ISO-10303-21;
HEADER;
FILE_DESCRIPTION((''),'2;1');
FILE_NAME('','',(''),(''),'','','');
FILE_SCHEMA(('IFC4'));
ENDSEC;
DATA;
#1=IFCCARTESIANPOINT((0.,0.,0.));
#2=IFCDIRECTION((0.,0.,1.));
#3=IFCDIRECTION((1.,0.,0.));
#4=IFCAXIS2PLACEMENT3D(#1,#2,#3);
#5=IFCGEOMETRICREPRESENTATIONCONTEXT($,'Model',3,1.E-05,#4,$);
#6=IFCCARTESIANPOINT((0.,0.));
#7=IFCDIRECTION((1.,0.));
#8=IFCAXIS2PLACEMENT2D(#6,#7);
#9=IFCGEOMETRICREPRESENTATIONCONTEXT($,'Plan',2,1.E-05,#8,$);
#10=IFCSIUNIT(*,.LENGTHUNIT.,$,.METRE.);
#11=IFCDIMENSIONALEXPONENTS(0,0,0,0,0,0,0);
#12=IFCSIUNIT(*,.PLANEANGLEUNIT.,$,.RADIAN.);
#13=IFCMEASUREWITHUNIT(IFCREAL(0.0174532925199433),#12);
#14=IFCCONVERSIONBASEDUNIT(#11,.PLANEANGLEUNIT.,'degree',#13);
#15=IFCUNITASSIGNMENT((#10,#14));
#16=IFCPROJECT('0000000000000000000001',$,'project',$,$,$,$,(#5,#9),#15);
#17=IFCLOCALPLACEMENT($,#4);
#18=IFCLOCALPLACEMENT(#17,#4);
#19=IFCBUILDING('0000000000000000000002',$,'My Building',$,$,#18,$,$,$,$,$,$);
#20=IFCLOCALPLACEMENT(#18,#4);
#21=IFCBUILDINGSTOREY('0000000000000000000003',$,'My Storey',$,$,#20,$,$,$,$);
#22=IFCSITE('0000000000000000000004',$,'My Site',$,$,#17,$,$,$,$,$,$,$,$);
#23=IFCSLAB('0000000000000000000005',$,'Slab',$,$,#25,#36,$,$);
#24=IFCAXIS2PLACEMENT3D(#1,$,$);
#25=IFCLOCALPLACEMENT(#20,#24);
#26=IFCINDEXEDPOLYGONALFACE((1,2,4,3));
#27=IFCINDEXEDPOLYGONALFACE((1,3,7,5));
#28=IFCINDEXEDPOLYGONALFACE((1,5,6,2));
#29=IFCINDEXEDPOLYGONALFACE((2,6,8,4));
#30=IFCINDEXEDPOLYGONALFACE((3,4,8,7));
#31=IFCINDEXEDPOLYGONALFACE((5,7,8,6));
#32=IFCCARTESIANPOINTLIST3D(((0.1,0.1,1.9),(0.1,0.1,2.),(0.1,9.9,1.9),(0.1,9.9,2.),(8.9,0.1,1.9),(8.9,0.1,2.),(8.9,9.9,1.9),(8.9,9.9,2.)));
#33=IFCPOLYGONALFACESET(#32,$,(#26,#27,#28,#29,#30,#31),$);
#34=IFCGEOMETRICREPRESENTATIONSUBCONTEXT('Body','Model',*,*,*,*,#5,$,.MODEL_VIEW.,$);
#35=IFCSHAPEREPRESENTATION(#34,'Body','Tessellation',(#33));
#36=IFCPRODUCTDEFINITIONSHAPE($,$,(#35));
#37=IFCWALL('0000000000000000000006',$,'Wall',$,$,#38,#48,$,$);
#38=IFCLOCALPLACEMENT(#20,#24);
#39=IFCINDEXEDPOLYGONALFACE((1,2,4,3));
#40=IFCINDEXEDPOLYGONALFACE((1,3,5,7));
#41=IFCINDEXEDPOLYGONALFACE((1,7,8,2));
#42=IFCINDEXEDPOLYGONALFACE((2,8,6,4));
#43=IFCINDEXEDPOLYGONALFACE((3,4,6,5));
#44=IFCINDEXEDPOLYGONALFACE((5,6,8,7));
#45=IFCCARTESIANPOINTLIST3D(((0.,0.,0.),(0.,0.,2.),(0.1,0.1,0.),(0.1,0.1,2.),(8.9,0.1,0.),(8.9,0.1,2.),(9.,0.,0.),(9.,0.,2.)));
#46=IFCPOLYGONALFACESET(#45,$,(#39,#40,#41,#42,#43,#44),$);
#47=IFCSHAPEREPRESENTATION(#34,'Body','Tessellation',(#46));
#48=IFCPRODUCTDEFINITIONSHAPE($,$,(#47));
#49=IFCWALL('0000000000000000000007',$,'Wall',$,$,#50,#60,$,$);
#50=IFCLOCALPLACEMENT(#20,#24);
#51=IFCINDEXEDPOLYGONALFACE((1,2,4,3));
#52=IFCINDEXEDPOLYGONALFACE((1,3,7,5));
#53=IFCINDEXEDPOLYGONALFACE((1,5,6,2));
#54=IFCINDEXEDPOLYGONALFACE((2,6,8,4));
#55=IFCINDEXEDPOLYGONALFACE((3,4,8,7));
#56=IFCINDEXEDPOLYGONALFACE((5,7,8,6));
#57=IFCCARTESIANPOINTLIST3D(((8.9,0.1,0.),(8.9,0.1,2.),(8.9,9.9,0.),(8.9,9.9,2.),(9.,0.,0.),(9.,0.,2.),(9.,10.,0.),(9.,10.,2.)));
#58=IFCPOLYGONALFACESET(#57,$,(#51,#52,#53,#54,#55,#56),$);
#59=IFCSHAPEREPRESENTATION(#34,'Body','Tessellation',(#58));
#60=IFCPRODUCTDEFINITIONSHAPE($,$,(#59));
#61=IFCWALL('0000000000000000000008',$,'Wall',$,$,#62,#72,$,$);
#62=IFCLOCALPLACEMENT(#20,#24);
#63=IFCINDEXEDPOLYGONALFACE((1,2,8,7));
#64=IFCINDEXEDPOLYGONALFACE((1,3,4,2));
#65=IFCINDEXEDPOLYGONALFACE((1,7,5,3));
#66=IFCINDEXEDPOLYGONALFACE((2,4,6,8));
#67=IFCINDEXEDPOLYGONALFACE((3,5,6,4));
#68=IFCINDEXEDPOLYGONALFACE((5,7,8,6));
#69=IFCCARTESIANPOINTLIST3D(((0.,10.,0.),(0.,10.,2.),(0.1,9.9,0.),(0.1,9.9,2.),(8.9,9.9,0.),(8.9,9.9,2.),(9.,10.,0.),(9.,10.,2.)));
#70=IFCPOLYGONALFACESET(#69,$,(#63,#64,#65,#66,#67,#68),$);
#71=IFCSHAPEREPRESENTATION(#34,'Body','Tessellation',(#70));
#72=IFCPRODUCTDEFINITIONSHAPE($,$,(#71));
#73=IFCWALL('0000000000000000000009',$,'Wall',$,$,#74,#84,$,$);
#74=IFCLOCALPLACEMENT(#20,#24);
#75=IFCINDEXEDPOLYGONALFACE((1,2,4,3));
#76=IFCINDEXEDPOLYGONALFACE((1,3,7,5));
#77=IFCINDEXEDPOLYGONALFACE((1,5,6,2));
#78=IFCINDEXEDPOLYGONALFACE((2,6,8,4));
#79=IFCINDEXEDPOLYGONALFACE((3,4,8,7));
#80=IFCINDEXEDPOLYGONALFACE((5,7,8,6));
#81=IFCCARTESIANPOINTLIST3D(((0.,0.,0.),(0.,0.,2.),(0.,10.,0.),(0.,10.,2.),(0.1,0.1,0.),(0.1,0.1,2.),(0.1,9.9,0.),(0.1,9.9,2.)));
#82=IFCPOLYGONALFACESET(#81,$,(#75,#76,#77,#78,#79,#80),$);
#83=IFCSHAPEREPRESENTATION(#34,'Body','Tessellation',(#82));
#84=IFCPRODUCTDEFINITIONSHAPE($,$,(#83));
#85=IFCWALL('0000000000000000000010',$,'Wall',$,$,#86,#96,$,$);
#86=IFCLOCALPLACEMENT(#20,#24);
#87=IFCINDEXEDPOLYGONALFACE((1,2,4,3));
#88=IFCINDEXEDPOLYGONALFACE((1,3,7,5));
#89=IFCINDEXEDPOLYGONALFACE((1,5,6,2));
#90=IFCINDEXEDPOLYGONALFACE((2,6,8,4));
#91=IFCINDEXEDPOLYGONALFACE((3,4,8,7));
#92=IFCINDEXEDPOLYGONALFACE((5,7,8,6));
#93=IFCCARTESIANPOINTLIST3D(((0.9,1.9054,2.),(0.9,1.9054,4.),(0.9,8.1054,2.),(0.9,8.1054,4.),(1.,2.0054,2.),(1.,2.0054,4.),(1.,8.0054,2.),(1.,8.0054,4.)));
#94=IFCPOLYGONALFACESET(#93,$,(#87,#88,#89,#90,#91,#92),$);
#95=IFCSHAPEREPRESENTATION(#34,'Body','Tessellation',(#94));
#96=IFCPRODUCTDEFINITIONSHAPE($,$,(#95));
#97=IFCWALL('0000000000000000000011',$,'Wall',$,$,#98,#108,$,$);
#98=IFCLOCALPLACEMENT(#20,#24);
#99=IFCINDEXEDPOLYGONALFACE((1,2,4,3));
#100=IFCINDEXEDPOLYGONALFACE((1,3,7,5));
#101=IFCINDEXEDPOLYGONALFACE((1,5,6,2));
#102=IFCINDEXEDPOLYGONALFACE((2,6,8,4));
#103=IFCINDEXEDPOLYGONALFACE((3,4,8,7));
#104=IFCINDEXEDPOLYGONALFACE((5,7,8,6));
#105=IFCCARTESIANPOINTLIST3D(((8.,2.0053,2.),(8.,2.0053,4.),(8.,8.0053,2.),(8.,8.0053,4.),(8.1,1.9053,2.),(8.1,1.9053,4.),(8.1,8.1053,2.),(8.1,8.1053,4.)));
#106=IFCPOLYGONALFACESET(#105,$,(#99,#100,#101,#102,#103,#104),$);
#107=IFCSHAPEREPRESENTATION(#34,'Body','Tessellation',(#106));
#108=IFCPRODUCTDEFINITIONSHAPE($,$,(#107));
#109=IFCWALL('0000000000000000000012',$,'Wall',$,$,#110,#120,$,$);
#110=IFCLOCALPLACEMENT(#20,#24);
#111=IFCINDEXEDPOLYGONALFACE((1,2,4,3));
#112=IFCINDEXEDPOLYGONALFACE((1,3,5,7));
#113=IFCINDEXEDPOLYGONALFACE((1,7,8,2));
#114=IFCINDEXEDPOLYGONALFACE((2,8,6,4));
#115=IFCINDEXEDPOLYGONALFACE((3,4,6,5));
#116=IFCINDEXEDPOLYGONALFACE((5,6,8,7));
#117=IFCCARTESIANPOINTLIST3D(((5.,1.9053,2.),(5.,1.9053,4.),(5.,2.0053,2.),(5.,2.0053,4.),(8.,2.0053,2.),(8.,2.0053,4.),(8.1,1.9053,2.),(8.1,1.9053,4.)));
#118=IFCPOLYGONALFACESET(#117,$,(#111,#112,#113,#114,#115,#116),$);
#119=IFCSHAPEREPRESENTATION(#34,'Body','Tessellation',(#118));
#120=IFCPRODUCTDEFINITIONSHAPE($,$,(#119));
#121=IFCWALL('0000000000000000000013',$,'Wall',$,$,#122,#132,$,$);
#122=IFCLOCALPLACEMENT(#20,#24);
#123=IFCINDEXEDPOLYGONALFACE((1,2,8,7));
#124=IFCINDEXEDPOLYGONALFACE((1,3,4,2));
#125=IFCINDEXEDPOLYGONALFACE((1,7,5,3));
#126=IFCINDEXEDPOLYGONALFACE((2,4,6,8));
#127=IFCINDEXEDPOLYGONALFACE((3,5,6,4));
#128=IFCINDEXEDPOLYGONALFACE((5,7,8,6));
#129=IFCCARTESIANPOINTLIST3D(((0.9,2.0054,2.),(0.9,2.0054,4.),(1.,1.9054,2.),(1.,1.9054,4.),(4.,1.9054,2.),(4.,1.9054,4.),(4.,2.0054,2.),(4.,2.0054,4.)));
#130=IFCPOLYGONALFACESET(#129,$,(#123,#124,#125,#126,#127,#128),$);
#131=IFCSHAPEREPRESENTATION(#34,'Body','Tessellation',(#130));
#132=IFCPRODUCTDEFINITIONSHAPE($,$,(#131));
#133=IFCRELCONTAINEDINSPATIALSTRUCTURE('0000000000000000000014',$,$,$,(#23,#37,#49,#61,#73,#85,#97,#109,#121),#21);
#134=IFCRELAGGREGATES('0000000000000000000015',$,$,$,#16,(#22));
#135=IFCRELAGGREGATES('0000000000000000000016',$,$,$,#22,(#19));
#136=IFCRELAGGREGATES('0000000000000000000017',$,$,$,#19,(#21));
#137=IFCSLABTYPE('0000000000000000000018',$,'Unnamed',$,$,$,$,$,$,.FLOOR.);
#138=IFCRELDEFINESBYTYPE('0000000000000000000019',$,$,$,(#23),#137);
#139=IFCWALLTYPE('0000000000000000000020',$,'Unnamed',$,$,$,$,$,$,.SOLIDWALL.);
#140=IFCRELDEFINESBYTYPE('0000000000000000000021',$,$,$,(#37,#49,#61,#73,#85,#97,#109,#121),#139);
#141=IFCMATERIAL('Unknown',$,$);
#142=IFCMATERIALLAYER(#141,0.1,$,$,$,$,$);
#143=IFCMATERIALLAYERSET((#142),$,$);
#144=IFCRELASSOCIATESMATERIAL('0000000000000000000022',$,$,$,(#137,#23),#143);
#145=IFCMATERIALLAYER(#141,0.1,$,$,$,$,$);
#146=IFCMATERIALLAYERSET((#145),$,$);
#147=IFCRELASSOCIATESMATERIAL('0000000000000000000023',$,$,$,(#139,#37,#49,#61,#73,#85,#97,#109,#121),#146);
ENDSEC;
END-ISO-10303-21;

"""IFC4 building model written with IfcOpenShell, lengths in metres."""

from ifc_helpers import new_model, entity, si_unit, converted_unit, frame, origin_with_axes, origin_2d_with_axis, place, context, subcontext, project, spatial, indexed_curve, outline, extrude, clip, halfspace, material, layer, layer_set, layer_usage, type_object, element, save


model = new_model("IFC4")

# Units and contexts
model_context = context("Model", 3, precision=1e-05, world=origin_with_axes())
plan_context = context("Plan", 2, precision=1e-05, world=origin_2d_with_axis())
body_context_1 = subcontext(model_context, "Body", "Model", "MODEL_VIEW")
ifc_project = project(units=[si_unit("LENGTHUNIT", "METRE"), converted_unit("PLANEANGLEUNIT", "degree", entity("IfcReal", 0.0174532925199433), si_unit("PLANEANGLEUNIT", "RADIAN"), dimensions=[0, 0, 0, 0, 0, 0, 0])], contexts=[model_context, plan_context])

# Site, building, storey
site_placement = place(None, origin_with_axes())
site = spatial("IfcSite", under=ifc_project, at=site_placement, Name="My Site")
building_placement = place(site_placement, origin_with_axes())
building = spatial("IfcBuilding", under=site, at=building_placement, Name="My Building")
storey_placement = place(building_placement, origin_with_axes())
storey = spatial("IfcBuildingStorey", under=building, at=storey_placement, Name="My Storey")

# Slab
ifc_material = material(Name="Unknown")
ifc_layer_1 = layer(ifc_material, 0.1)
ifc_layer_set_1 = layer_set([ifc_layer_1])
ifc_layer_usage_1 = layer_usage(ifc_layer_set_1, "AXIS3", "POSITIVE", -0.1)
slab_type = type_object("IfcSlabType", Name="Unnamed", PredefinedType="FLOOR", material=ifc_layer_set_1)
slab_placement = place(storey_placement, frame((0.1, 9.9, 2.0), z_axis=(0.0, 0.0, 1.0), x_axis=(1.0, 0.0, 0.0)))
element("IfcSlab", 1, at=slab_placement, inside=storey, type_object=slab_type, material=ifc_layer_usage_1, Name="Slab", context=body_context_1, shape_type="SweptSolid", body=[
    extrude(outline(indexed_curve([(0.0, 0.0), (8.8, 0.0), (8.8, -9.8), (0.0, -9.8), (0.0, 0.0)])), frame((0.0, 0.0, -0.1), z_axis=(0.0, 0.0, 1.0), x_axis=(1.0, 0.0, 0.0)), (0.0, 0.0, 1.0), 0.1),
])

# Walls
ifc_layer_2 = layer(ifc_material, 0.1)
ifc_layer_set_2 = layer_set([ifc_layer_2])
ifc_layer_usage_2 = layer_usage(ifc_layer_set_2, "AXIS2", "POSITIVE", 0.0)
wall_type = type_object("IfcWallType", Name="Unnamed", PredefinedType="SOLIDWALL", material=ifc_layer_set_2)
wall_1_placement = place(storey_placement, origin_with_axes())
element("IfcWall", 2, at=wall_1_placement, inside=storey, type_object=wall_type, material=ifc_layer_usage_2, Name="Wall", context=body_context_1, shape_type="Clipping", body=[
    clip(clip(extrude(outline(indexed_curve([(0.0, 0.0), (0.0, 0.1), (9.0, 0.1), (9.0, 0.0), (0.0, 0.0)], self_intersect=False)), origin_with_axes(), (0.0, 0.0, 1.0), 2.0), halfspace(frame((9.0, 0.0, 0.0), z_axis=(0.707105, 0.707108, 0.0), x_axis=(0.707108, -0.707105, 0.0)), False)), halfspace(frame((0.0, 0.0, 0.0), z_axis=(-0.707107, 0.707107, 0.0), x_axis=(0.707107, 0.707107, 0.0)), False)),
])
ifc_layer_usage_3 = layer_usage(ifc_layer_set_2, "AXIS2", "POSITIVE", 0.0)
wall_2_placement = place(storey_placement, frame((9.0, 0.0, 0.0), z_axis=(0.0, 0.0, 1.0), x_axis=(0.0, 1.0, 0.0)))
element("IfcWall", 3, at=wall_2_placement, inside=storey, type_object=wall_type, material=ifc_layer_usage_3, Name="Wall", context=body_context_1, shape_type="Clipping", body=[
    clip(clip(extrude(outline(indexed_curve([(0.0, 0.0), (0.0, 0.1), (10.0, 0.1), (10.0, 0.0), (0.0, 0.0)], self_intersect=False)), origin_with_axes(), (0.0, 0.0, 1.0), 2.0), halfspace(frame((10.0, 0.0, 0.0), z_axis=(0.707107, 0.707107, 0.0), x_axis=(0.707107, -0.707107, 0.0)), False)), halfspace(frame((0.0, 0.0, 0.0), z_axis=(-0.707108, 0.707105, 0.0), x_axis=(0.707105, 0.707108, 0.0)), False)),
])
ifc_layer_usage_4 = layer_usage(ifc_layer_set_2, "AXIS2", "POSITIVE", 0.0)
wall_3_placement = place(storey_placement, frame((9.0, 10.0, 0.0), z_axis=(0.0, 0.0, 1.0), x_axis=(-1.0, 0.0, 0.0)))
element("IfcWall", 4, at=wall_3_placement, inside=storey, type_object=wall_type, material=ifc_layer_usage_4, Name="Wall", context=body_context_1, shape_type="Clipping", body=[
    clip(clip(extrude(outline(indexed_curve([(0.0, 0.0), (0.0, 0.1), (9.0, 0.1), (9.0, 0.0), (0.0, 0.0)], self_intersect=False)), origin_with_axes(), (0.0, 0.0, 1.0), 2.0), halfspace(frame((9.0, 0.0, 0.0), z_axis=(0.707108, 0.707106, 0.0), x_axis=(0.707106, -0.707108, 0.0)), False)), halfspace(frame((0.0, 0.0, 0.0), z_axis=(-0.707107, 0.707107, 0.0), x_axis=(0.707107, 0.707107, 0.0)), False)),
])
ifc_layer_usage_5 = layer_usage(ifc_layer_set_2, "AXIS2", "POSITIVE", 0.0)
wall_4_placement = place(storey_placement, frame((0.0, 10.0, 0.0), z_axis=(0.0, 0.0, 1.0), x_axis=(0.0, -1.0, 0.0)))
element("IfcWall", 5, at=wall_4_placement, inside=storey, type_object=wall_type, material=ifc_layer_usage_5, Name="Wall", context=body_context_1, shape_type="Clipping", body=[
    clip(clip(extrude(outline(indexed_curve([(0.0, 0.0), (0.0, 0.1), (10.0, 0.1), (10.0, 0.0), (0.0, 0.0)], self_intersect=False)), origin_with_axes(), (0.0, 0.0, 1.0), 2.0), halfspace(frame((10.0, 0.0, 0.0), z_axis=(0.707107, 0.707107, 0.0), x_axis=(0.707107, -0.707107, 0.0)), False)), halfspace(frame((0.0, 0.0, 0.0), z_axis=(-0.707105, 0.707108, 0.0), x_axis=(0.707108, 0.707105, 0.0)), False)),
])
ifc_layer_usage_6 = layer_usage(ifc_layer_set_2, "AXIS2", "POSITIVE", 0.0)
wall_5_placement = place(storey_placement, frame((1.0, 1.9054, 2.0), z_axis=(0.0, 0.0, 1.0), x_axis=(0.0, 1.0, 0.0)))
element("IfcWall", 6, at=wall_5_placement, inside=storey, type_object=wall_type, material=ifc_layer_usage_6, Name="Wall", context=body_context_1, shape_type="Clipping", body=[
    clip(clip(extrude(outline(indexed_curve([(0.0, 0.0), (0.0, 0.1), (6.2, 0.1), (6.2, 0.0), (0.0, 0.0)], self_intersect=False)), origin_with_axes(), (0.0, 0.0, 1.0), 2.0), halfspace(frame((6.1, 0.0, 0.0), z_axis=(0.707107, -0.707107, 0.0), x_axis=(-0.707107, -0.707107, 0.0)), False)), halfspace(frame((0.1, 0.0, 0.0), z_axis=(-0.707107, -0.707106, 0.0), x_axis=(-0.707106, 0.707107, 0.0)), False)),
])

# Walls
ifc_layer_usage_7 = layer_usage(ifc_layer_set_2, "AXIS2", "POSITIVE", 0.0)
wall_6_placement = place(storey_placement, frame((8.0, 8.1053, 2.0), z_axis=(0.0, 0.0, 1.0), x_axis=(0.0, -1.0, 0.0)))
element("IfcWall", 7, at=wall_6_placement, inside=storey, type_object=wall_type, material=ifc_layer_usage_7, Name="Wall", context=body_context_1, shape_type="Clipping", body=[
    clip(clip(extrude(outline(indexed_curve([(0.0, 0.0), (0.0, 0.1), (6.2, 0.1), (6.2, 0.0), (0.0, 0.0)], self_intersect=False)), origin_with_axes(), (0.0, 0.0, 1.0), 2.0), halfspace(frame((6.1, 0.0, 0.0), z_axis=(0.70711, -0.707103, 0.0), x_axis=(-0.707103, -0.70711, 0.0)), False)), halfspace(frame((0.1, 0.0, 0.0), z_axis=(-0.707108, -0.707105, 0.0), x_axis=(-0.707105, 0.707108, 0.0)), False)),
])
ifc_layer_usage_8 = layer_usage(ifc_layer_set_2, "AXIS2", "POSITIVE", 0.0)
wall_7_placement = place(storey_placement, frame((8.1, 2.0053, 2.0), z_axis=(0.0, 0.0, 1.0), x_axis=(-1.0, 0.0, 0.0)))
element("IfcWall", 8, at=wall_7_placement, inside=storey, type_object=wall_type, material=ifc_layer_usage_8, Name="Wall", context=body_context_1, shape_type="Clipping", body=[
    clip(extrude(outline(indexed_curve([(0.0, 0.0), (0.0, 0.1), (3.1, 0.1), (3.1, 0.0), (0.0, 0.0)], self_intersect=False)), origin_with_axes(), (0.0, 0.0, 1.0), 2.0), halfspace(frame((0.1, 0.0, 0.0), z_axis=(-0.707103, -0.70711, 0.0), x_axis=(-0.70711, 0.707103, 0.0)), False)),
])
ifc_layer_usage_9 = layer_usage(ifc_layer_set_2, "AXIS2", "POSITIVE", 0.0)
wall_8_placement = place(storey_placement, frame((0.9, 1.9054, 2.0), z_axis=(0.0, 0.0, 1.0), x_axis=(1.0, 0.0, 0.0)))
element("IfcWall", 9, at=wall_8_placement, inside=storey, type_object=wall_type, material=ifc_layer_usage_9, Name="Wall", context=body_context_1, shape_type="Clipping", body=[
    clip(extrude(outline(indexed_curve([(0.0, 0.0), (0.0, 0.1), (3.1, 0.1), (3.1, 0.0), (0.0, 0.0)], self_intersect=False)), origin_with_axes(), (0.0, 0.0, 1.0), 2.0), halfspace(frame((0.1, 0.0, 0.0), z_axis=(-0.707103, -0.70711, 0.0), x_axis=(-0.70711, 0.707103, 0.0)), False)),
])

save(model, "model.ifc")
